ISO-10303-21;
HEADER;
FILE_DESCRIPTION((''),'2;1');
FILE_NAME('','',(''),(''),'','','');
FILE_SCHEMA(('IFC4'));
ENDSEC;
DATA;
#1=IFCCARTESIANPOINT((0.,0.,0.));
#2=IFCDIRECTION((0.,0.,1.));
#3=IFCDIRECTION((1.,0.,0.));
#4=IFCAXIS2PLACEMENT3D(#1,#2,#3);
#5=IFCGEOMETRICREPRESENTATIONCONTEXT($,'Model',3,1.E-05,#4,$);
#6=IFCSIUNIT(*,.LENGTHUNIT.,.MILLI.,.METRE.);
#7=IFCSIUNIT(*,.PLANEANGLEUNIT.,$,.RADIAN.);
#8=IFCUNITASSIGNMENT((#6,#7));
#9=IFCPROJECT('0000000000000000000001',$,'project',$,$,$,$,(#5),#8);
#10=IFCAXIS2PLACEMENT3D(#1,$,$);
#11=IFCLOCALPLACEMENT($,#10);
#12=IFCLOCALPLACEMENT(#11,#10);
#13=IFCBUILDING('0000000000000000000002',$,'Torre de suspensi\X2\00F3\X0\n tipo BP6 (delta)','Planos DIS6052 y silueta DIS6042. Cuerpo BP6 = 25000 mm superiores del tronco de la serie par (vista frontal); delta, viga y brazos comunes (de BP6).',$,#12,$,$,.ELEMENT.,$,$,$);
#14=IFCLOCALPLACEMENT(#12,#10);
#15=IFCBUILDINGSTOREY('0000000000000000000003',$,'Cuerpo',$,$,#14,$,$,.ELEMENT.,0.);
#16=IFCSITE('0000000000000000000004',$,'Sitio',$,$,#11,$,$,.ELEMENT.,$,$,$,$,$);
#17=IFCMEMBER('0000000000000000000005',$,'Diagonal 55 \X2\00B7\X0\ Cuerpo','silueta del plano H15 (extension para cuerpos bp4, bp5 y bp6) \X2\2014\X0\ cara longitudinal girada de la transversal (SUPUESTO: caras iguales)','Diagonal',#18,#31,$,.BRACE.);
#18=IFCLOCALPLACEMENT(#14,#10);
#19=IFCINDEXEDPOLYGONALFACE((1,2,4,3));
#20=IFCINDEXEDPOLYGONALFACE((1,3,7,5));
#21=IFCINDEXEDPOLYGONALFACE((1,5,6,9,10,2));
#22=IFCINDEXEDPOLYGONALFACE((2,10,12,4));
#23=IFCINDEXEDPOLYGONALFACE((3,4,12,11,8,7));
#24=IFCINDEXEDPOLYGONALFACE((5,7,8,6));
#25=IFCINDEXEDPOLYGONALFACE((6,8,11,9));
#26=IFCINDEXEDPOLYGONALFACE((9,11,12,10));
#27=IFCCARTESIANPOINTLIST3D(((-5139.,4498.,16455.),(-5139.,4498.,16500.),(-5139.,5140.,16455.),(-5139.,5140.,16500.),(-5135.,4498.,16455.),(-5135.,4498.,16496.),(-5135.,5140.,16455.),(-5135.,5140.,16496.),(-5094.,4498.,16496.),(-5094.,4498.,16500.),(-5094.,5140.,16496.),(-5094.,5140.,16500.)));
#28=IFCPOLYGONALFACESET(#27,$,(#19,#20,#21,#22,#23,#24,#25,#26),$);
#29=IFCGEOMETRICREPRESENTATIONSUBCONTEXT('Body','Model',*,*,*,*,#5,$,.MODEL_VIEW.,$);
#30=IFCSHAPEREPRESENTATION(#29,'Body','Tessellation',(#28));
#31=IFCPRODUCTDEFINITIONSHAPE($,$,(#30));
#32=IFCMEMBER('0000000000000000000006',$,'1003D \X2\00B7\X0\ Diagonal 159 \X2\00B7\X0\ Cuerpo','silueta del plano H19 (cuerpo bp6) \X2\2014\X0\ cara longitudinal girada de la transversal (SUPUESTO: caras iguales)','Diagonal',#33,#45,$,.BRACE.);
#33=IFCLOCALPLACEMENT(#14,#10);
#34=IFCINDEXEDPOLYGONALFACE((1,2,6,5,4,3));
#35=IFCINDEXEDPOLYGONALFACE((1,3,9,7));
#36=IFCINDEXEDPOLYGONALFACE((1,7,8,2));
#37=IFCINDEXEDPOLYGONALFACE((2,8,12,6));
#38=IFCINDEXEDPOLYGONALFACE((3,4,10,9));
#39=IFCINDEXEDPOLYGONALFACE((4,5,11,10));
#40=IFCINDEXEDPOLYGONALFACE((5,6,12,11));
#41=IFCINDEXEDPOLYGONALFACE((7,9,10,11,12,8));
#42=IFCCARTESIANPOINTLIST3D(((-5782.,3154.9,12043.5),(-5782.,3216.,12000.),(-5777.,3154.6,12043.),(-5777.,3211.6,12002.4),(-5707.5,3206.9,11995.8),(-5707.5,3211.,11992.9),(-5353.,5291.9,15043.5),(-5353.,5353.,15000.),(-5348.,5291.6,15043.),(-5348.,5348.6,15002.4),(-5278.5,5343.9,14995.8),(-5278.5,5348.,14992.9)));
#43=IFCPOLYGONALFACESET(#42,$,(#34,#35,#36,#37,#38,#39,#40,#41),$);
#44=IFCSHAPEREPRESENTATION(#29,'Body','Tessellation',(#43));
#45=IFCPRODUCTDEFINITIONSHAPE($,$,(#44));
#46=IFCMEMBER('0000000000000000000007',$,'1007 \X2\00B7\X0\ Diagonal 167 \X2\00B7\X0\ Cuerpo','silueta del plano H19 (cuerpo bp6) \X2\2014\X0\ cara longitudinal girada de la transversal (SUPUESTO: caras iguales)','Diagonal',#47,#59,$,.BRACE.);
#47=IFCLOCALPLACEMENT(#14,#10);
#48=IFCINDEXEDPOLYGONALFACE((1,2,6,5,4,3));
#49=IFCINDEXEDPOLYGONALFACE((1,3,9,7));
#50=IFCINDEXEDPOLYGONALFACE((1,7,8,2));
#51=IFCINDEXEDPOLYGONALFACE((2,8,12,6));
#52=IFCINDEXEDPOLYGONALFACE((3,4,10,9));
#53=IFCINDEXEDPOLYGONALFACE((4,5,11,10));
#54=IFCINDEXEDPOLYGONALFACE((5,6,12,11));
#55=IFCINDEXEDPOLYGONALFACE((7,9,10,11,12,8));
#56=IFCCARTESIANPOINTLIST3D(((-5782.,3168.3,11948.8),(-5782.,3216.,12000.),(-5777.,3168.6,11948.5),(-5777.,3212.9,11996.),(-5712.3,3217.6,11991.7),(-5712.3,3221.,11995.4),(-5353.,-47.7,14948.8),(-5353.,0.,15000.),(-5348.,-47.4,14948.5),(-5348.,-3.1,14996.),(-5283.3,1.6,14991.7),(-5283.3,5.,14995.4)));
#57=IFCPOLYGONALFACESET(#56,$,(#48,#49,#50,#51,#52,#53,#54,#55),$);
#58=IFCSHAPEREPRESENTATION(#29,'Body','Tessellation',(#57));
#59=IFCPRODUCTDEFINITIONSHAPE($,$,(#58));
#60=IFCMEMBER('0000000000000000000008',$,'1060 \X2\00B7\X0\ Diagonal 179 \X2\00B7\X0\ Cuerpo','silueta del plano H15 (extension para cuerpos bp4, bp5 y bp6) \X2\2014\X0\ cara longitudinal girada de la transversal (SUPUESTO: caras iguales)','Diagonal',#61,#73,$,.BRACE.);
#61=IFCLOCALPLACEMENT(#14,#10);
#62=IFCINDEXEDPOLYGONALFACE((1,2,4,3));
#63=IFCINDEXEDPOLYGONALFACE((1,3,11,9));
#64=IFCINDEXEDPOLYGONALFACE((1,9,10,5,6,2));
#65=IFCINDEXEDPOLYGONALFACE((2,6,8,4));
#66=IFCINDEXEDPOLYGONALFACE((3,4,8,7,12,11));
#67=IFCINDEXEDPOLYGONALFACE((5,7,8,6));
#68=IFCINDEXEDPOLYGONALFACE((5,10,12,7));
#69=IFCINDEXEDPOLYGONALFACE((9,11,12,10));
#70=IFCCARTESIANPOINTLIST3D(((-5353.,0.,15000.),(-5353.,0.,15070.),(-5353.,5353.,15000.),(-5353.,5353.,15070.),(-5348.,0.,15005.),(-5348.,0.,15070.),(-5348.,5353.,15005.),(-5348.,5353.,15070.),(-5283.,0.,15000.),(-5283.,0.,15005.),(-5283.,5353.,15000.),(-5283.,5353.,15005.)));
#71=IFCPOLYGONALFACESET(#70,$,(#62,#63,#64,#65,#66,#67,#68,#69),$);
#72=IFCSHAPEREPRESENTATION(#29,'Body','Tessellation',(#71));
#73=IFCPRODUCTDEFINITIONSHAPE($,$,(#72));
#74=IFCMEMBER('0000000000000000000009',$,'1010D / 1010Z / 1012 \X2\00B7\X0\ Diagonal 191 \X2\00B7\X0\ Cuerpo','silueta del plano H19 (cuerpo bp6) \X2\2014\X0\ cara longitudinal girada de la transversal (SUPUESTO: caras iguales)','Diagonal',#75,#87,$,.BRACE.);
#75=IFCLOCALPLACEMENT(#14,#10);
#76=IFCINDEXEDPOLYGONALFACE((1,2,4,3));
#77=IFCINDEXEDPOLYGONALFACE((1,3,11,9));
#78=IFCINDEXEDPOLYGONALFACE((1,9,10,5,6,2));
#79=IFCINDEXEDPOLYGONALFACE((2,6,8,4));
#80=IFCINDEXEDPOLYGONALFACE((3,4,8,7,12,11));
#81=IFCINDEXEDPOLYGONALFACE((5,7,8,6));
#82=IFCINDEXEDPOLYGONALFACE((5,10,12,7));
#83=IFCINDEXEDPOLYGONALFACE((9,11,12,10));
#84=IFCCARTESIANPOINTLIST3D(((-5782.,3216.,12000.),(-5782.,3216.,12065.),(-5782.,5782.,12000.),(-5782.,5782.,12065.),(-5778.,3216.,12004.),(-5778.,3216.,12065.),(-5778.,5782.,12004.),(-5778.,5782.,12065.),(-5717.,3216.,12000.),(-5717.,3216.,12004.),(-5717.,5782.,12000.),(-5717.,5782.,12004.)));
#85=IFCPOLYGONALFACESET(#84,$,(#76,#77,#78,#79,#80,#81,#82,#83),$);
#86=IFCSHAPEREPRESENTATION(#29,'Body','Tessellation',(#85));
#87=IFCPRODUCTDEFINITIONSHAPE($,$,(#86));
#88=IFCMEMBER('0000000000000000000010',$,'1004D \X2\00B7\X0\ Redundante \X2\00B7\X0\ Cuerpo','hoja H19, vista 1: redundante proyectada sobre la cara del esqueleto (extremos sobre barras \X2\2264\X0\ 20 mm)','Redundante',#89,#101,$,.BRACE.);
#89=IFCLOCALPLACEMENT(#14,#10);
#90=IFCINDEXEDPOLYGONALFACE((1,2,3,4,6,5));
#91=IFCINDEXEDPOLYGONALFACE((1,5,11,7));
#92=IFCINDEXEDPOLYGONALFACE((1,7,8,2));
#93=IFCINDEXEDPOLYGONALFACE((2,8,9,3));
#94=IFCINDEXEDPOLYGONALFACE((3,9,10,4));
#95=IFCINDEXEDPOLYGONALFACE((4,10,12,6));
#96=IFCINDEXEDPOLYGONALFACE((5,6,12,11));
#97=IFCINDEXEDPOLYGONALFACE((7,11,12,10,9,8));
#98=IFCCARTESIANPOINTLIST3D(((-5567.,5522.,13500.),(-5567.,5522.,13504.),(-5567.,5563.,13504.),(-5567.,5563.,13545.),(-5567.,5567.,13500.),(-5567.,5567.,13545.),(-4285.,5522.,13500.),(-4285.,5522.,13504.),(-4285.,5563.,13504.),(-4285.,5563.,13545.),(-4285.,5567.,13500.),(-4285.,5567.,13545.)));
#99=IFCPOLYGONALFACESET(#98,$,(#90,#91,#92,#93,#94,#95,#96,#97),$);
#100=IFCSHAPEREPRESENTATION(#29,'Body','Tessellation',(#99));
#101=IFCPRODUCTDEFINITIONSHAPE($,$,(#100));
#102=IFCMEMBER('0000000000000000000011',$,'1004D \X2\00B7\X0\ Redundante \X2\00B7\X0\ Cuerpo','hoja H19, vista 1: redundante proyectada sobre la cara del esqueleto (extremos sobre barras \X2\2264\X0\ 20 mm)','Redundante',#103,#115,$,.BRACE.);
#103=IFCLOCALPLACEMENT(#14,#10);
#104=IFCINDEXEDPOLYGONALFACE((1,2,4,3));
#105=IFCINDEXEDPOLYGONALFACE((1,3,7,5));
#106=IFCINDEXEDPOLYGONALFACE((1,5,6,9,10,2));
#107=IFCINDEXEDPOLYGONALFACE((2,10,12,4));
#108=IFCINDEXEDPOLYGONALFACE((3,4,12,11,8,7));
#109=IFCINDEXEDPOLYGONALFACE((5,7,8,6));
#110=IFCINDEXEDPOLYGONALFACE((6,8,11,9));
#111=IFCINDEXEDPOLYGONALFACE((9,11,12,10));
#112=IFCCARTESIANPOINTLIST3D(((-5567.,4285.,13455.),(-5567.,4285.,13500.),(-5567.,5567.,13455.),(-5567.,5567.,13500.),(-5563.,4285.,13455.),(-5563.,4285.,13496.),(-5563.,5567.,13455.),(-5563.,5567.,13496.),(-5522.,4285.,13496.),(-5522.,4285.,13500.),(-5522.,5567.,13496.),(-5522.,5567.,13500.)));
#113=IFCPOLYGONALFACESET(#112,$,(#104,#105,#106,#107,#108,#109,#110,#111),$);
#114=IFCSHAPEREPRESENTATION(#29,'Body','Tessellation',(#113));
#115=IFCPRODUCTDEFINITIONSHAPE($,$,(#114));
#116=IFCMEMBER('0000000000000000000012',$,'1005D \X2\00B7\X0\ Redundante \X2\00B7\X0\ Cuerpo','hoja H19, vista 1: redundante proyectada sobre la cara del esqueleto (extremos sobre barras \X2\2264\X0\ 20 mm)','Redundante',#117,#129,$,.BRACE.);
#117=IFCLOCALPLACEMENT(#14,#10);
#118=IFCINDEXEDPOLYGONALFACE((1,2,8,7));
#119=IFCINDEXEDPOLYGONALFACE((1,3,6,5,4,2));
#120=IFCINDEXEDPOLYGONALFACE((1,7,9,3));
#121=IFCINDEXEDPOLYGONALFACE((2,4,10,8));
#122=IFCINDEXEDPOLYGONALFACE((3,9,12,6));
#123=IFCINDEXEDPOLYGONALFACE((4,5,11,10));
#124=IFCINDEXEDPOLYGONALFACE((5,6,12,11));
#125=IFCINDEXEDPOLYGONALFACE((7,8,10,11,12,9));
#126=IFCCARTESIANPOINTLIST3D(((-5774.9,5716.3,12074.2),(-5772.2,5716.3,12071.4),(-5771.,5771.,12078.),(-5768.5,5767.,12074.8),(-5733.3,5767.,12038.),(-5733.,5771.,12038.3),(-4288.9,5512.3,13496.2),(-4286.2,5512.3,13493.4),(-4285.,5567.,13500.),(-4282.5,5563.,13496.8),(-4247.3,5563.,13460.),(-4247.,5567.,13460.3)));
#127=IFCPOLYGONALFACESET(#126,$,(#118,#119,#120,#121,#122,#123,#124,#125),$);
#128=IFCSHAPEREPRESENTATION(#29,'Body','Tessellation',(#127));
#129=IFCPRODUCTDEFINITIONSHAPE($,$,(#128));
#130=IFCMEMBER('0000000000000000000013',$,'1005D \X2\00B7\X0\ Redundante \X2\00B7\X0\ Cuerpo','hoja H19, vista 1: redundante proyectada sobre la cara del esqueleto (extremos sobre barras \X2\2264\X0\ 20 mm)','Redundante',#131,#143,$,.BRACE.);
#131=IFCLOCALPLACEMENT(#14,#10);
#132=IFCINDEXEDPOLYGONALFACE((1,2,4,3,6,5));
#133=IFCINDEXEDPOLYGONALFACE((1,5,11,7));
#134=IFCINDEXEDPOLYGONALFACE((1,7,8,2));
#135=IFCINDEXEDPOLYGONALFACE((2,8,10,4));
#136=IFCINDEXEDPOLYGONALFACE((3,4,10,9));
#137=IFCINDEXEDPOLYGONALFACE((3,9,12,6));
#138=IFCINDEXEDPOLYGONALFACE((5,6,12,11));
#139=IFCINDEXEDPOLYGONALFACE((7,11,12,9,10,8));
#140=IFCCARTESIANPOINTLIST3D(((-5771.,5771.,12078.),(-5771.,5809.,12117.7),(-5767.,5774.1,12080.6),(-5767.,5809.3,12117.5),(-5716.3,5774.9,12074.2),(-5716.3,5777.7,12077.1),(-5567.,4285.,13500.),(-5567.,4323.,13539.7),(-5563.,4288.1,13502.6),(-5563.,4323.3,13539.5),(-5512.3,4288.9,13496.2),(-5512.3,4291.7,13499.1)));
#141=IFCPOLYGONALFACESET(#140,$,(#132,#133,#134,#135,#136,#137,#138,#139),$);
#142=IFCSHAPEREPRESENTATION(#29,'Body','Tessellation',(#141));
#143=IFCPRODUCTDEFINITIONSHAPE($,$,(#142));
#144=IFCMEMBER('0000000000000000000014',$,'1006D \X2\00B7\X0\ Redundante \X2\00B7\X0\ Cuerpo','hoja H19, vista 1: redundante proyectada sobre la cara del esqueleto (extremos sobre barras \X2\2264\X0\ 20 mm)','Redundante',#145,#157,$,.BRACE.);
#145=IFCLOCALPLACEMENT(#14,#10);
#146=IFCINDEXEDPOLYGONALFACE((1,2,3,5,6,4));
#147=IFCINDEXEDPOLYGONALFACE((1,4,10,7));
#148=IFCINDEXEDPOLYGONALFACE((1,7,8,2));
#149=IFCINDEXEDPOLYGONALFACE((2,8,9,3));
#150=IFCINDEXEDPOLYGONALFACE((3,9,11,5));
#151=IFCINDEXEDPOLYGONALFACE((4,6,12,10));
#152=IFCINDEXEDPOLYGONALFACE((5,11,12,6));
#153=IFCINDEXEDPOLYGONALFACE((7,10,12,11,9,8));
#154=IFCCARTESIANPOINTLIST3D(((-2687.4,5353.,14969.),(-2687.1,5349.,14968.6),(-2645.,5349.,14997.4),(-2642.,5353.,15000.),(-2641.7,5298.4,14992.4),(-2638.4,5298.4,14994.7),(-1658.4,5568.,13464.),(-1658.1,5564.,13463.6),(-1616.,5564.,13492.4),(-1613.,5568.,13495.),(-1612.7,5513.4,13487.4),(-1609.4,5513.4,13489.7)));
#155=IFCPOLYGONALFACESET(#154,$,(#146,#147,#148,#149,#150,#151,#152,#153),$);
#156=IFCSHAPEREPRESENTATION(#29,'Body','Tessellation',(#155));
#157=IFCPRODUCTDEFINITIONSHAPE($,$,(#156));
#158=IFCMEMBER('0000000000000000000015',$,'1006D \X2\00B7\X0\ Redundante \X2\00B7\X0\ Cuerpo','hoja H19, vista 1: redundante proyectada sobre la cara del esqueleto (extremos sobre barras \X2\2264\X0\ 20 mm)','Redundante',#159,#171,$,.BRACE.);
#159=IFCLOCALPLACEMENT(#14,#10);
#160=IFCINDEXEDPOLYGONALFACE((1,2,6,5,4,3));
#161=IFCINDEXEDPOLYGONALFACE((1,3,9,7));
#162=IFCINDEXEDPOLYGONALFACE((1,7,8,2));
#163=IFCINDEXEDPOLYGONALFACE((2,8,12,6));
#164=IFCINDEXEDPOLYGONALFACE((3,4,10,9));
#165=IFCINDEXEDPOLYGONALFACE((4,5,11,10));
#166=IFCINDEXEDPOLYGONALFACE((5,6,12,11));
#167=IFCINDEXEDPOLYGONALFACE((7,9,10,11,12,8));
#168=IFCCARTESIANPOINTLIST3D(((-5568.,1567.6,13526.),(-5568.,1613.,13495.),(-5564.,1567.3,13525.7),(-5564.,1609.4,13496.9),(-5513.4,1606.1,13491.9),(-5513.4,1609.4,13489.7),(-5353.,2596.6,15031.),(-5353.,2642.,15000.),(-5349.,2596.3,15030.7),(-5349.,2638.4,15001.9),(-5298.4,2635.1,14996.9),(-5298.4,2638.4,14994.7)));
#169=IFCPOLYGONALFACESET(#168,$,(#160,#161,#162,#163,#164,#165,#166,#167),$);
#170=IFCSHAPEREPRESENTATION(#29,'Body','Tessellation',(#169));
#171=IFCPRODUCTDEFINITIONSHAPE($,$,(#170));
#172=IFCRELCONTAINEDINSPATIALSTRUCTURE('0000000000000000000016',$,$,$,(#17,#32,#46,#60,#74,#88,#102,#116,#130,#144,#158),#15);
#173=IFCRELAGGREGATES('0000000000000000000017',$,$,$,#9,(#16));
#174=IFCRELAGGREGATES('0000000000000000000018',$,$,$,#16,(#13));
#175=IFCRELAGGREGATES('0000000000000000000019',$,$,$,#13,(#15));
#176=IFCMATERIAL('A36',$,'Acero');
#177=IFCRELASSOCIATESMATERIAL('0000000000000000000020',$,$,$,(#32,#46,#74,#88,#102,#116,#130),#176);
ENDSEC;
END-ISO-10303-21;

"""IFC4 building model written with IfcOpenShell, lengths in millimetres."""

from ifc_helpers import new_model, si_unit, frame, frame_2d, origin, origin_with_axes, place, context, subcontext, project, spatial, l_section, extrude, material, element, save


model = new_model("IFC4")

# Units and contexts
model_context = context("Model", 3, precision=1e-05, world=origin_with_axes())
body_context = subcontext(model_context, "Body", "Model", "MODEL_VIEW")
ifc_project = project(units=[si_unit("LENGTHUNIT", "METRE", prefix="MILLI"), si_unit("PLANEANGLEUNIT", "RADIAN")], contexts=[model_context])

# Site, building, storey
site_placement = place(None, origin())
site = spatial("IfcSite", under=ifc_project, at=site_placement, Name="Sitio", CompositionType="ELEMENT")
building_placement = place(site_placement, origin())
building = spatial("IfcBuilding", under=site, at=building_placement, Name="Torre de suspensión tipo BP6 (delta)", Description="Planos DIS6052 y silueta DIS6042. Cuerpo BP6 = 25000 mm superiores del tronco de la serie par (vista frontal); delta, viga y brazos comunes (de BP6).", CompositionType="ELEMENT")
storey_placement = place(building_placement, origin())
storey = spatial("IfcBuildingStorey", under=building, at=storey_placement, Name="Cuerpo", CompositionType="ELEMENT", Elevation=0.0)

# Members
ifc_material_1 = material(Name="A36", Category="Acero")
member_1_placement = place(storey_placement, frame((-5139.0, 4498.0, 16500.0), z_axis=(0.0, 1.0, 0.0), x_axis=(1.0, 0.0, 0.0)))
element("IfcMember", 1, at=member_1_placement, inside=storey, Name="Diagonal 55 · Cuerpo", Description="silueta del plano H15 (extension para cuerpos bp4, bp5 y bp6) — cara longitudinal girada de la transversal (SUPUESTO: caras iguales)", ObjectType="Diagonal", PredefinedType="BRACE", context=body_context, shape_type="SweptSolid", body=[
    extrude(l_section(Depth=45.0, Width=45.0, Thickness=4.0, at=frame_2d((22.5, 22.5))), None, (0.0, 0.0, 1.0), 642.0),
])
member_2_placement = place(storey_placement, frame((-5353.0, 5353.0, 15000.0), z_axis=(-0.115689, -0.576289, -0.809016), x_axis=(0.993285, -0.067121, -0.094227)))
element("IfcMember", 2, at=member_2_placement, inside=storey, material=ifc_material_1, Name="1003D · Diagonal 159 · Cuerpo", Description="silueta del plano H19 (cuerpo bp6) — cara longitudinal girada de la transversal (SUPUESTO: caras iguales)", ObjectType="Diagonal", PredefinedType="BRACE", context=body_context, shape_type="SweptSolid", body=[
    extrude(l_section(Depth=75.0, Width=75.0, Thickness=5.0, at=frame_2d((37.5, 37.5))), None, (0.0, 0.0, 1.0), 3708.2),
])
member_3_placement = place(storey_placement, frame((-5353.0, 0.0, 15000.0), z_axis=(-0.097083, 0.727783, -0.678902), x_axis=(0.995276, 0.070991, -0.066223)))
element("IfcMember", 3, at=member_3_placement, inside=storey, material=ifc_material_1, Name="1007 · Diagonal 167 · Cuerpo", Description="silueta del plano H19 (cuerpo bp6) — cara longitudinal girada de la transversal (SUPUESTO: caras iguales)", ObjectType="Diagonal", PredefinedType="BRACE", context=body_context, shape_type="SweptSolid", body=[
    extrude(l_section(Depth=70.0, Width=70.0, Thickness=5.0, at=frame_2d((35.0, 35.0))), None, (0.0, 0.0, 1.0), 4418.9),
])
member_4_placement = place(storey_placement, frame((-5353.0, 5353.0, 15000.0), z_axis=(0.0, -1.0, 0.0), x_axis=(1.0, 0.0, 0.0)))
element("IfcMember", 4, at=member_4_placement, inside=storey, Name="1060 · Diagonal 179 · Cuerpo", Description="silueta del plano H15 (extension para cuerpos bp4, bp5 y bp6) — cara longitudinal girada de la transversal (SUPUESTO: caras iguales)", ObjectType="Diagonal", PredefinedType="BRACE", context=body_context, shape_type="SweptSolid", body=[
    extrude(l_section(Depth=70.0, Width=70.0, Thickness=5.0, at=frame_2d((35.0, 35.0))), None, (0.0, 0.0, 1.0), 5353.0),
])
member_5_placement = place(storey_placement, frame((-5782.0, 5782.0, 12000.0), z_axis=(0.0, -1.0, 0.0), x_axis=(1.0, 0.0, 0.0)))
element("IfcMember", 5, at=member_5_placement, inside=storey, material=ifc_material_1, Name="1010D / 1010Z / 1012 · Diagonal 191 · Cuerpo", Description="silueta del plano H19 (cuerpo bp6) — cara longitudinal girada de la transversal (SUPUESTO: caras iguales)", ObjectType="Diagonal", PredefinedType="BRACE", context=body_context, shape_type="SweptSolid", body=[
    extrude(l_section(Depth=65.0, Width=65.0, Thickness=4.0, at=frame_2d((32.5, 32.5))), None, (0.0, 0.0, 1.0), 2566.0),
])
for number, where, z_axis, x_axis, name in (
    (6, (-4285.0, 5567.0, 13500.0), (-1.0, 0.0, 0.0), (0.0, -1.0, 0.0), "1004D · Redundante · Cuerpo"),
    (7, (-5567.0, 4285.0, 13500.0), (0.0, 1.0, 0.0), (1.0, 0.0, 0.0), "1004D · Redundante · Cuerpo"),
):
    element("IfcMember", number, at=place(storey_placement, frame(where, z_axis=z_axis, x_axis=x_axis)), inside=storey, material=ifc_material_1, Name=name, Description="hoja H19, vista 1: redundante proyectada sobre la cara del esqueleto (extremos sobre barras ≤ 20 mm)", ObjectType="Redundante", PredefinedType="BRACE", context=body_context, shape_type="SweptSolid", body=[
        extrude(l_section(Depth=45.0, Width=45.0, Thickness=4.0, at=frame_2d((22.5, 22.5))), None, (0.0, 0.0, 1.0), 1282.0),
    ])
for number, where, z_axis, x_axis, name in (
    (8, (-5771.0, 5771.0, 12078.0), (0.718966, -0.098701, 0.688001), (-0.071311, -0.995117, -0.068239), "1005D · Redundante · Cuerpo"),
    (9, (-5771.0, 5771.0, 12078.0), (0.098701, -0.718966, 0.688001), (0.995117, 0.071311, -0.068239), "1005D · Redundante · Cuerpo"),
):
    element("IfcMember", number, at=place(storey_placement, frame(where, z_axis=z_axis, x_axis=x_axis)), inside=storey, material=ifc_material_1, Name=name, Description="hoja H19, vista 1: redundante proyectada sobre la cara del esqueleto (extremos sobre barras ≤ 20 mm)", ObjectType="Redundante", PredefinedType="BRACE", context=body_context, shape_type="SweptSolid", body=[
        extrude(l_section(Depth=55.0, Width=55.0, Thickness=4.0, at=frame_2d((27.5, 27.5))), None, (0.0, 0.0, 1.0), 2066.9),
    ])
for number, where, z_axis, x_axis, name in (
    (10, (-2642.0, 5353.0, 15000.0), (0.560524, 0.117116, -0.819815), (0.066101, -0.993118, -0.096679), "1006D · Redundante · Cuerpo"),
    (11, (-5353.0, 2642.0, 15000.0), (-0.117116, -0.560524, -0.819815), (0.993118, -0.066101, -0.096679), "1006D · Redundante · Cuerpo"),
):
    element("IfcMember", number, at=place(storey_placement, frame(where, z_axis=z_axis, x_axis=x_axis)), inside=storey, Name=name, Description="hoja H19, vista 1: redundante proyectada sobre la cara del esqueleto (extremos sobre barras ≤ 20 mm)", ObjectType="Redundante", PredefinedType="BRACE", context=body_context, shape_type="SweptSolid", body=[
        extrude(l_section(Depth=55.0, Width=55.0, Thickness=4.0, at=frame_2d((27.5, 27.5))), None, (0.0, 0.0, 1.0), 1835.8),
    ])

save(model, "model.ifc")
